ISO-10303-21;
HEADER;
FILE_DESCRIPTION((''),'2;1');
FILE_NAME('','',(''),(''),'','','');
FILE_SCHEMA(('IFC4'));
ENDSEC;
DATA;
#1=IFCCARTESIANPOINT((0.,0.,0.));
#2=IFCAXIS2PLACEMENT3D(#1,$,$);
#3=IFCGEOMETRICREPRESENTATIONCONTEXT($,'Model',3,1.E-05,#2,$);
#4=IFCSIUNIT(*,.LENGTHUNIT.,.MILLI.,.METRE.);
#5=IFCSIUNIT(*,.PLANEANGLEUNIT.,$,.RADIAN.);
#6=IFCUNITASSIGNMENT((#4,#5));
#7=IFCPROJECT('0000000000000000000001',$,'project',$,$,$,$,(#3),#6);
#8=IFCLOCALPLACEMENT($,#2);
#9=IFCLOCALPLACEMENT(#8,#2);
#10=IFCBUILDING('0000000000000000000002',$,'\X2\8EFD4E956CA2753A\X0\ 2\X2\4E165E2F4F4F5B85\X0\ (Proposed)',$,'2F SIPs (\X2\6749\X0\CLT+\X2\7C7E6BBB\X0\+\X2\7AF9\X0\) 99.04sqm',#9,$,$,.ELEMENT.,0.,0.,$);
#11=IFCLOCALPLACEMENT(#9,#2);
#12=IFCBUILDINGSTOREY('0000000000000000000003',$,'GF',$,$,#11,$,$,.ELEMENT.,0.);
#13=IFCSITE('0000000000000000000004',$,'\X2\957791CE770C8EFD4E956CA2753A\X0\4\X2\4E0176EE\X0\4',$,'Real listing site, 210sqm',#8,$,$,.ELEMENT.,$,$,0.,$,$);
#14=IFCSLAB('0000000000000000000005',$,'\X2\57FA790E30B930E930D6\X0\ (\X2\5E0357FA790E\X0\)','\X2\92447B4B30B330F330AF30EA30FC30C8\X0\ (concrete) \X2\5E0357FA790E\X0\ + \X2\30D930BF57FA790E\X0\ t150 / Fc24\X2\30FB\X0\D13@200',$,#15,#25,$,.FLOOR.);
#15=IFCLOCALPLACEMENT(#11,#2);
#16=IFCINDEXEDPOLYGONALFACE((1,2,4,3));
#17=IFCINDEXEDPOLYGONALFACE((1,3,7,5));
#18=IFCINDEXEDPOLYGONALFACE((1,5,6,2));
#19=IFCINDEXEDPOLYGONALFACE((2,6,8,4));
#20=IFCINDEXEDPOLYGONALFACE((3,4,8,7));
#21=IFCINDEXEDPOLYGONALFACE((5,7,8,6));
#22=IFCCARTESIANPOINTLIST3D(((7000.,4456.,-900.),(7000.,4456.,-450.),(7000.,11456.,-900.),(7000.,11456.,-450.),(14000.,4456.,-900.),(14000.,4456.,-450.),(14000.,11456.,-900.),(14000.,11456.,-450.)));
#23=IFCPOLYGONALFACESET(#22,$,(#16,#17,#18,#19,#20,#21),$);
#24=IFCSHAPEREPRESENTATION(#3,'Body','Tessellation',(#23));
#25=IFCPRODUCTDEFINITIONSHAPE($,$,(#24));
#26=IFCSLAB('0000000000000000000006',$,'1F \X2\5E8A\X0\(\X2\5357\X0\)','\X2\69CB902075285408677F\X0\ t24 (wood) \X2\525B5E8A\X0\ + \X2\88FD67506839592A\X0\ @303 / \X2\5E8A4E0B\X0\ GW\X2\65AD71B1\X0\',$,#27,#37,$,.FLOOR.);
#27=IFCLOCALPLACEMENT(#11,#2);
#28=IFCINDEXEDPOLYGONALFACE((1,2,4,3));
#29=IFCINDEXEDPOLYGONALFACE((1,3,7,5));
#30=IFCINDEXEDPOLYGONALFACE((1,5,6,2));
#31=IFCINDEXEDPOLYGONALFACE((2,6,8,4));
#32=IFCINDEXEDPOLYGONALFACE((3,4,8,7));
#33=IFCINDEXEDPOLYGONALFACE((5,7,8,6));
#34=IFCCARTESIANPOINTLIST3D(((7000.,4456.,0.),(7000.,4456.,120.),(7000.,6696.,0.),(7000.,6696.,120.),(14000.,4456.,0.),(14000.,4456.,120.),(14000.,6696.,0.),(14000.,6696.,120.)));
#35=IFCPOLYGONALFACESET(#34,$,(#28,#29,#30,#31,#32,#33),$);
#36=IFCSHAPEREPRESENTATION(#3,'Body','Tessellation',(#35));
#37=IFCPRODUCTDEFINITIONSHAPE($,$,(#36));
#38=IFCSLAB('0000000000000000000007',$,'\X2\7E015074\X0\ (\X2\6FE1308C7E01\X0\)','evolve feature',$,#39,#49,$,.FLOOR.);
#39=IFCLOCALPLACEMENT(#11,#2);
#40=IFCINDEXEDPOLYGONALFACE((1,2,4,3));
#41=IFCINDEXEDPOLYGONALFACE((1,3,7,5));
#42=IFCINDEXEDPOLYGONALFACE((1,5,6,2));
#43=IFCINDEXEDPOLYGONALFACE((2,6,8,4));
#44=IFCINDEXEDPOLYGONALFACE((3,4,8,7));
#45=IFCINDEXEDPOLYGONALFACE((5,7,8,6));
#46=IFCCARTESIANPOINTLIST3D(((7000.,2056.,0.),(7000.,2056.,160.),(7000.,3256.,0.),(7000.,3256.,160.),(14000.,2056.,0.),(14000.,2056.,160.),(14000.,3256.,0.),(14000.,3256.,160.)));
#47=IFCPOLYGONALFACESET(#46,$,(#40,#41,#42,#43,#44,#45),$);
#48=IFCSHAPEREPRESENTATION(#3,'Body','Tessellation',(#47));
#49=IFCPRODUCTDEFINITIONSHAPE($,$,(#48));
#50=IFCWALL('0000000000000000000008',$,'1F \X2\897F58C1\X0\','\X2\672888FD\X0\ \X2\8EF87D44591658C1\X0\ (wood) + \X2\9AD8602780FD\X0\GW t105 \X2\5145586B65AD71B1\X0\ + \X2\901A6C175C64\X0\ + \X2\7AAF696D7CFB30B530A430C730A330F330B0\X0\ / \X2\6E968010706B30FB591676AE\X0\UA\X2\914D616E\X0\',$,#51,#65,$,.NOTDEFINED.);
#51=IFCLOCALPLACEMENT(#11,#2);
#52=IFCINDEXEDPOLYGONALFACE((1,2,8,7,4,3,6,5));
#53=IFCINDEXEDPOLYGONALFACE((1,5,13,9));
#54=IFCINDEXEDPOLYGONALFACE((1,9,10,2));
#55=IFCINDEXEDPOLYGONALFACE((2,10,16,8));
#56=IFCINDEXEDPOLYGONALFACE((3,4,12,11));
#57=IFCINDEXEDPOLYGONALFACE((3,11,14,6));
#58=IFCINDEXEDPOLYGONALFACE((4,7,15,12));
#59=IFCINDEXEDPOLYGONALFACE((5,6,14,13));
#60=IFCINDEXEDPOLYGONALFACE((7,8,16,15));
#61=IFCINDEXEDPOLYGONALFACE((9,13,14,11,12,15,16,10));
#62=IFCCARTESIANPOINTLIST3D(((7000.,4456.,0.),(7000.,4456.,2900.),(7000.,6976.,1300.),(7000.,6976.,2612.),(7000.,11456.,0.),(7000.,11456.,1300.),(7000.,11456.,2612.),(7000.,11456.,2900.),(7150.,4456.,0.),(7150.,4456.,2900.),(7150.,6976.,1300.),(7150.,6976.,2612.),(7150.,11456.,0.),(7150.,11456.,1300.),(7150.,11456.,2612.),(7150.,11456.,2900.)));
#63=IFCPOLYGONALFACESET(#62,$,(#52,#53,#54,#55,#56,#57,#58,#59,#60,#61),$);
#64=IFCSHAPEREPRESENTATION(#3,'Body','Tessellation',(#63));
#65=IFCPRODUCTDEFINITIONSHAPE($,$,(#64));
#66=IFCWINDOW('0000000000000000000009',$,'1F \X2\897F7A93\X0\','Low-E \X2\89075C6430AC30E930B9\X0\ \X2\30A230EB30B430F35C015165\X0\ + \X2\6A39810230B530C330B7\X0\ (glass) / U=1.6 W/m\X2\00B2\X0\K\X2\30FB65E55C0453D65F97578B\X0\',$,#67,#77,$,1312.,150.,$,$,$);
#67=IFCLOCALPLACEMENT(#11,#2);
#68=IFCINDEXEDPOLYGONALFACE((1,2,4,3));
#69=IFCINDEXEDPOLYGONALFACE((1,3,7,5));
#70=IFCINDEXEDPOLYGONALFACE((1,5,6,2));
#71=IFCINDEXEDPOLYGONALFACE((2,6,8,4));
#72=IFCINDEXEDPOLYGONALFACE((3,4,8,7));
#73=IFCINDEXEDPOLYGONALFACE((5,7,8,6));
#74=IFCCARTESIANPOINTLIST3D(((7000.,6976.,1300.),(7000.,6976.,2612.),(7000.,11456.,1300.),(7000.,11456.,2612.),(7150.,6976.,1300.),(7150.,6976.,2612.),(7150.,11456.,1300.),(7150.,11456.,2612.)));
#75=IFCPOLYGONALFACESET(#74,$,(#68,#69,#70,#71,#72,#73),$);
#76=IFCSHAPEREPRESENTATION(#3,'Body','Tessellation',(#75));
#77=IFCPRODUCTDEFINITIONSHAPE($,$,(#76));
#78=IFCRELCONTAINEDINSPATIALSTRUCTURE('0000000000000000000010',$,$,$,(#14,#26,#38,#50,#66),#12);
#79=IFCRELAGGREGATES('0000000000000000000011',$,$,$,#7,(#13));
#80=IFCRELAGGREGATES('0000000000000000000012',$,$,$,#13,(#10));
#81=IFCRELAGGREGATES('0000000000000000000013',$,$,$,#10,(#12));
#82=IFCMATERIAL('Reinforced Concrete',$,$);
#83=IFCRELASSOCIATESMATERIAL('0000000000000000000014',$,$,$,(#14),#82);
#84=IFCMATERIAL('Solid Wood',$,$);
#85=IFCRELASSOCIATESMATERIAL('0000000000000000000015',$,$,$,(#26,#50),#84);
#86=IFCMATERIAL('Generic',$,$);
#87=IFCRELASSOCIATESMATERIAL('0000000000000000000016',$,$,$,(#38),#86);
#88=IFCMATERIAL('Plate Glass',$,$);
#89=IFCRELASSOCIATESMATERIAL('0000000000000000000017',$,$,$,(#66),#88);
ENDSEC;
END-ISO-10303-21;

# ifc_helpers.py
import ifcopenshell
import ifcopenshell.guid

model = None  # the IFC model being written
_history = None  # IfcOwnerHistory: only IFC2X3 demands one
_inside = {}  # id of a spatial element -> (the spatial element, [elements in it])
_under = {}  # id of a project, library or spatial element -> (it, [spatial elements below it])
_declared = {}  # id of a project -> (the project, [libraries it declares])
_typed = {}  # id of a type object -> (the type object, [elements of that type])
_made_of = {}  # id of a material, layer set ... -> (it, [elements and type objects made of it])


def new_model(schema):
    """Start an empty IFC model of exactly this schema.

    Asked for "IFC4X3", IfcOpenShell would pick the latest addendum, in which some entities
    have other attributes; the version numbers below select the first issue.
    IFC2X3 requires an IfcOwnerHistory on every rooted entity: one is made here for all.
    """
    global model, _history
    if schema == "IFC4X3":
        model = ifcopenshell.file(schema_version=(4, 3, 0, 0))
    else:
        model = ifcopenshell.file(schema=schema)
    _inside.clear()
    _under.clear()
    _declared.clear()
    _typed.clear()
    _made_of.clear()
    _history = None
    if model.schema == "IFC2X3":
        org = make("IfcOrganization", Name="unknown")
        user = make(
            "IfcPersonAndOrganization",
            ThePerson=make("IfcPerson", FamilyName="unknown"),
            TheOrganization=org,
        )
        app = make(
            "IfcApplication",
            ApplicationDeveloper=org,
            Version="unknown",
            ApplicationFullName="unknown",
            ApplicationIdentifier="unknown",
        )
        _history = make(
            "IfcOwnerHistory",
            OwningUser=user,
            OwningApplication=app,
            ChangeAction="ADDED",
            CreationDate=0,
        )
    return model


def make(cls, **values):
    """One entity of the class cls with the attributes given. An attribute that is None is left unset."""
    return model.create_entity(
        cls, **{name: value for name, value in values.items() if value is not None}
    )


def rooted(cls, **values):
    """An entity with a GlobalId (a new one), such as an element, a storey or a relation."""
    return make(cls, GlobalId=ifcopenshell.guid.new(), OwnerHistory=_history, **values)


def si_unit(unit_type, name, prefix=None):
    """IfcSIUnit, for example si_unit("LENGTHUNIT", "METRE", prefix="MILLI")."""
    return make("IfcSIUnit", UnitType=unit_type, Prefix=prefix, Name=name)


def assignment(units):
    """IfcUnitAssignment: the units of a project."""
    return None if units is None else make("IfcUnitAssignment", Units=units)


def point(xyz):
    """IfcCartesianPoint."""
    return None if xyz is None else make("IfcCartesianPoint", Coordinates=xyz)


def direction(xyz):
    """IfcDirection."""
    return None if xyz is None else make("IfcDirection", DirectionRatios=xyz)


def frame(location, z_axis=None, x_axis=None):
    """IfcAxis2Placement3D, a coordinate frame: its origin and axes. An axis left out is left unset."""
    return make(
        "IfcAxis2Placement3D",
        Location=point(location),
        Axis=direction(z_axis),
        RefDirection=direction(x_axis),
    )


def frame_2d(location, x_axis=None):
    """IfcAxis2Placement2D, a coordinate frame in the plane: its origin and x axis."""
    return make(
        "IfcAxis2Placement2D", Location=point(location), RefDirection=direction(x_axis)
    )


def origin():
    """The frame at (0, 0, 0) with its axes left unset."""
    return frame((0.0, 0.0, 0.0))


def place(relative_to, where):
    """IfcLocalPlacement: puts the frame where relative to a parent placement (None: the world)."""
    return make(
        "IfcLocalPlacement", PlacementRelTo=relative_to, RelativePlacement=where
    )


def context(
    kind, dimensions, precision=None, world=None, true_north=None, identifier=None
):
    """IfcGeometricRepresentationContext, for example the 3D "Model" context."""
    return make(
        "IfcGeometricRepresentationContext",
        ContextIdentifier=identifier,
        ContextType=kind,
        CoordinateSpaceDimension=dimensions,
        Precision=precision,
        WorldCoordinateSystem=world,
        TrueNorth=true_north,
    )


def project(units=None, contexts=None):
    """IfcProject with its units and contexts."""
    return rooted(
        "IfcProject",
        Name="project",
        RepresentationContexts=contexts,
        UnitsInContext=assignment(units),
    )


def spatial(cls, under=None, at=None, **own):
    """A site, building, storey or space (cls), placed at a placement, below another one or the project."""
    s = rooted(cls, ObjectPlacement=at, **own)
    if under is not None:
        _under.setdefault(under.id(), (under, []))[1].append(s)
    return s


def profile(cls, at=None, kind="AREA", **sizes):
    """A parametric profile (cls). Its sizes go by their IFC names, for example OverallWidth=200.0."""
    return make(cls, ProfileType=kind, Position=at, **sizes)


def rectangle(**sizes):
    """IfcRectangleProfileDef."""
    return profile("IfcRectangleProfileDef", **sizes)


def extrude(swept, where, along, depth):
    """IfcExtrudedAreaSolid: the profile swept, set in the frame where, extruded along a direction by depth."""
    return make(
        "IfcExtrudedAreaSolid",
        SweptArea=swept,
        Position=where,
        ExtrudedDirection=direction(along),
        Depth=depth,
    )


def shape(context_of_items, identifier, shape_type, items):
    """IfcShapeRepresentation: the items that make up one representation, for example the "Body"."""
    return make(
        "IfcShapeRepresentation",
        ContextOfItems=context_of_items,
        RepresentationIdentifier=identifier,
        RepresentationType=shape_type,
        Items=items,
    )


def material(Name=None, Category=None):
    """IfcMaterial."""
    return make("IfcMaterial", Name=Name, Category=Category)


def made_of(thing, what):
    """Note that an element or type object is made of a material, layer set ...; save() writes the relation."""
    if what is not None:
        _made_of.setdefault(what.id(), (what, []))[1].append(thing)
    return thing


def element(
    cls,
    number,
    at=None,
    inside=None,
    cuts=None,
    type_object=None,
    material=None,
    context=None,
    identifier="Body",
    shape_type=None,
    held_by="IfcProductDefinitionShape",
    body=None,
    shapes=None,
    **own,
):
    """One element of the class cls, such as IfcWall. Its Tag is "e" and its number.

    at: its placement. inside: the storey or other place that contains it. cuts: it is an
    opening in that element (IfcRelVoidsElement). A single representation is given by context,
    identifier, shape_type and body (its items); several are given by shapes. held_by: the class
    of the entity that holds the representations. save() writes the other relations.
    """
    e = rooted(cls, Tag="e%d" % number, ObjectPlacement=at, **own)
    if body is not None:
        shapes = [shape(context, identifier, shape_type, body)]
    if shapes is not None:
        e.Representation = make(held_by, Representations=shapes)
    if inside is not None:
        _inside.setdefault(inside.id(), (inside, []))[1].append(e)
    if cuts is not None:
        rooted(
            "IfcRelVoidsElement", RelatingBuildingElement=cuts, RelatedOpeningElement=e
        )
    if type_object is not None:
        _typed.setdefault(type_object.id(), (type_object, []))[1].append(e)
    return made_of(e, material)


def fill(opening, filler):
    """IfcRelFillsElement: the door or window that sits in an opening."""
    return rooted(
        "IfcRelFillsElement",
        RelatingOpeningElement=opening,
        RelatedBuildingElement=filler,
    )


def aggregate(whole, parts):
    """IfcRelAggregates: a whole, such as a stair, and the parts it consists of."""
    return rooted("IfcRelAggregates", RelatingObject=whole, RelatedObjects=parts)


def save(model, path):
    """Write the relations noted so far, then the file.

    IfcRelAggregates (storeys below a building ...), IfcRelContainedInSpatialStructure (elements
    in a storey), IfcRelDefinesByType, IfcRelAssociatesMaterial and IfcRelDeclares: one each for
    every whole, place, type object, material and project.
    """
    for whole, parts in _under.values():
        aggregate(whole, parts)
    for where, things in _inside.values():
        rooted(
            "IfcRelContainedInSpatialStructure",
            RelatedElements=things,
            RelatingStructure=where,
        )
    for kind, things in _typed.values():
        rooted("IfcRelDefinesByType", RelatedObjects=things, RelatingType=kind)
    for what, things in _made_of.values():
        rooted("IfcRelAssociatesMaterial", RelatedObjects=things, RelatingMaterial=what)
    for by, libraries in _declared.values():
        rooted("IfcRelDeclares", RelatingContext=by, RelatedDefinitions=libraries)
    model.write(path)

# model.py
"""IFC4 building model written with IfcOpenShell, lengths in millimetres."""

from ifc_helpers import new_model, si_unit, frame, frame_2d, origin, place, context, project, spatial, rectangle, extrude, material, element, fill, save


model = new_model("IFC4")

# Units and contexts
model_context = context("Model", 3, precision=1e-05, world=origin())
ifc_project = project(units=[si_unit("LENGTHUNIT", "METRE", prefix="MILLI"), si_unit("PLANEANGLEUNIT", "RADIAN")], contexts=[model_context])

# Site, building, storey
site_placement = place(None, origin())
site = spatial("IfcSite", under=ifc_project, at=site_placement, Name="長野県軽井沢町4丁目4", ObjectType="Real listing site, 210sqm", CompositionType="ELEMENT", RefElevation=0.0)
building_placement = place(site_placement, origin())
building = spatial("IfcBuilding", under=site, at=building_placement, Name="軽井沢町 2世帯住宅 (Proposed)", ObjectType="2F SIPs (杉CLT+籾殻+竹) 99.04sqm", CompositionType="ELEMENT", ElevationOfRefHeight=0.0, ElevationOfTerrain=0.0)
storey_placement = place(building_placement, origin())
storey = spatial("IfcBuildingStorey", under=building, at=storey_placement, Name="GF", CompositionType="ELEMENT", Elevation=0.0)

# Slabs
ifc_material_1 = material(Name="Reinforced Concrete")
slab_1_placement = place(storey_placement, frame((3500.0, 2228.0, -450.0)))
element("IfcSlab", 1, at=slab_1_placement, inside=storey, material=ifc_material_1, Name="基礎スラブ (布基礎)", Description="鉄筋コンクリート (concrete) 布基礎 + ベタ基礎 t150 / Fc24・D13@200", PredefinedType="FLOOR", context=model_context, shape_type="SweptSolid", body=[
    extrude(rectangle(XDim=7000.0, YDim=7000.0, at=frame_2d((3500.0, 3500.0))), frame((3500.0, 2228.0, -450.0)), (0.0, 0.0, 1.0), 450.0),
])
ifc_material_2 = material(Name="Solid Wood")
slab_2_placement = place(storey_placement, frame((3500.0, 2228.0, 0.0)))
element("IfcSlab", 2, at=slab_2_placement, inside=storey, material=ifc_material_2, Name="1F 床(南)", Description="構造用合板 t24 (wood) 剛床 + 製材根太 @303 / 床下 GW断熱", PredefinedType="FLOOR", context=model_context, shape_type="SweptSolid", body=[
    extrude(rectangle(XDim=7000.0, YDim=2240.0, at=frame_2d((3500.0, 1120.0))), frame((3500.0, 2228.0, 0.0)), (0.0, 0.0, 1.0), 120.0),
])
ifc_material_3 = material(Name="Generic")
slab_3_placement = place(storey_placement, frame((3500.0, 1028.0, 0.0)))
element("IfcSlab", 3, at=slab_3_placement, inside=storey, material=ifc_material_3, Name="縁側 (濡れ縁)", Description="evolve feature", PredefinedType="FLOOR", context=model_context, shape_type="SweptSolid", body=[
    extrude(rectangle(XDim=7000.0, YDim=1200.0, at=frame_2d((3500.0, 600.0))), frame((3500.0, 1028.0, 0.0)), (0.0, 0.0, 1.0), 160.0),
])

# Shared definitions
ifc_material_4 = material(Name="Plate Glass")

# Wall, opening, window
wall_1_placement = place(storey_placement, frame((3500.0, 2228.0, 0.0)))
wall_1 = element("IfcWall", 4, at=wall_1_placement, inside=storey, material=ifc_material_2, Name="1F 西壁", Description="木製 軸組外壁 (wood) + 高性能GW t105 充填断熱 + 通気層 + 窯業系サイディング / 準耐火・外皮UA配慮", PredefinedType="NOTDEFINED", context=model_context, shape_type="SweptSolid", body=[
    extrude(rectangle(XDim=150.0, YDim=7000.0, at=frame_2d((75.0, 3500.0))), frame((3500.0, 2228.0, 0.0)), (0.0, 0.0, 1.0), 2900.0),
])
opening_1_placement = place(storey_placement, frame((3500.0, 3488.0, 650.0)))
opening_1 = element("IfcOpeningElement", 5, at=opening_1_placement, cuts=wall_1, PredefinedType="NOTDEFINED", context=model_context, shape_type="SweptSolid", body=[
    extrude(rectangle(XDim=150.0, YDim=4480.0, at=frame_2d((75.0, 2240.0))), frame((3500.0, 3488.0, 650.0)), (0.0, 0.0, 1.0), 1312.0),
])
window_1_placement = place(storey_placement, frame((3500.0, 3488.0, 650.0)))
window_1 = element("IfcWindow", 6, at=window_1_placement, inside=storey, material=ifc_material_4, Name="1F 西窓", Description="Low-E 複層ガラス アルゴン封入 + 樹脂サッシ (glass) / U=1.6 W/m²K・日射取得型", OverallHeight=1312.0, OverallWidth=150.0, context=model_context, shape_type="SweptSolid", body=[
    extrude(rectangle(XDim=150.0, YDim=4480.0, at=frame_2d((75.0, 2240.0))), frame((3500.0, 3488.0, 650.0)), (0.0, 0.0, 1.0), 1312.0),
])
fill(opening_1, window_1)

save(model, "model.ifc")
